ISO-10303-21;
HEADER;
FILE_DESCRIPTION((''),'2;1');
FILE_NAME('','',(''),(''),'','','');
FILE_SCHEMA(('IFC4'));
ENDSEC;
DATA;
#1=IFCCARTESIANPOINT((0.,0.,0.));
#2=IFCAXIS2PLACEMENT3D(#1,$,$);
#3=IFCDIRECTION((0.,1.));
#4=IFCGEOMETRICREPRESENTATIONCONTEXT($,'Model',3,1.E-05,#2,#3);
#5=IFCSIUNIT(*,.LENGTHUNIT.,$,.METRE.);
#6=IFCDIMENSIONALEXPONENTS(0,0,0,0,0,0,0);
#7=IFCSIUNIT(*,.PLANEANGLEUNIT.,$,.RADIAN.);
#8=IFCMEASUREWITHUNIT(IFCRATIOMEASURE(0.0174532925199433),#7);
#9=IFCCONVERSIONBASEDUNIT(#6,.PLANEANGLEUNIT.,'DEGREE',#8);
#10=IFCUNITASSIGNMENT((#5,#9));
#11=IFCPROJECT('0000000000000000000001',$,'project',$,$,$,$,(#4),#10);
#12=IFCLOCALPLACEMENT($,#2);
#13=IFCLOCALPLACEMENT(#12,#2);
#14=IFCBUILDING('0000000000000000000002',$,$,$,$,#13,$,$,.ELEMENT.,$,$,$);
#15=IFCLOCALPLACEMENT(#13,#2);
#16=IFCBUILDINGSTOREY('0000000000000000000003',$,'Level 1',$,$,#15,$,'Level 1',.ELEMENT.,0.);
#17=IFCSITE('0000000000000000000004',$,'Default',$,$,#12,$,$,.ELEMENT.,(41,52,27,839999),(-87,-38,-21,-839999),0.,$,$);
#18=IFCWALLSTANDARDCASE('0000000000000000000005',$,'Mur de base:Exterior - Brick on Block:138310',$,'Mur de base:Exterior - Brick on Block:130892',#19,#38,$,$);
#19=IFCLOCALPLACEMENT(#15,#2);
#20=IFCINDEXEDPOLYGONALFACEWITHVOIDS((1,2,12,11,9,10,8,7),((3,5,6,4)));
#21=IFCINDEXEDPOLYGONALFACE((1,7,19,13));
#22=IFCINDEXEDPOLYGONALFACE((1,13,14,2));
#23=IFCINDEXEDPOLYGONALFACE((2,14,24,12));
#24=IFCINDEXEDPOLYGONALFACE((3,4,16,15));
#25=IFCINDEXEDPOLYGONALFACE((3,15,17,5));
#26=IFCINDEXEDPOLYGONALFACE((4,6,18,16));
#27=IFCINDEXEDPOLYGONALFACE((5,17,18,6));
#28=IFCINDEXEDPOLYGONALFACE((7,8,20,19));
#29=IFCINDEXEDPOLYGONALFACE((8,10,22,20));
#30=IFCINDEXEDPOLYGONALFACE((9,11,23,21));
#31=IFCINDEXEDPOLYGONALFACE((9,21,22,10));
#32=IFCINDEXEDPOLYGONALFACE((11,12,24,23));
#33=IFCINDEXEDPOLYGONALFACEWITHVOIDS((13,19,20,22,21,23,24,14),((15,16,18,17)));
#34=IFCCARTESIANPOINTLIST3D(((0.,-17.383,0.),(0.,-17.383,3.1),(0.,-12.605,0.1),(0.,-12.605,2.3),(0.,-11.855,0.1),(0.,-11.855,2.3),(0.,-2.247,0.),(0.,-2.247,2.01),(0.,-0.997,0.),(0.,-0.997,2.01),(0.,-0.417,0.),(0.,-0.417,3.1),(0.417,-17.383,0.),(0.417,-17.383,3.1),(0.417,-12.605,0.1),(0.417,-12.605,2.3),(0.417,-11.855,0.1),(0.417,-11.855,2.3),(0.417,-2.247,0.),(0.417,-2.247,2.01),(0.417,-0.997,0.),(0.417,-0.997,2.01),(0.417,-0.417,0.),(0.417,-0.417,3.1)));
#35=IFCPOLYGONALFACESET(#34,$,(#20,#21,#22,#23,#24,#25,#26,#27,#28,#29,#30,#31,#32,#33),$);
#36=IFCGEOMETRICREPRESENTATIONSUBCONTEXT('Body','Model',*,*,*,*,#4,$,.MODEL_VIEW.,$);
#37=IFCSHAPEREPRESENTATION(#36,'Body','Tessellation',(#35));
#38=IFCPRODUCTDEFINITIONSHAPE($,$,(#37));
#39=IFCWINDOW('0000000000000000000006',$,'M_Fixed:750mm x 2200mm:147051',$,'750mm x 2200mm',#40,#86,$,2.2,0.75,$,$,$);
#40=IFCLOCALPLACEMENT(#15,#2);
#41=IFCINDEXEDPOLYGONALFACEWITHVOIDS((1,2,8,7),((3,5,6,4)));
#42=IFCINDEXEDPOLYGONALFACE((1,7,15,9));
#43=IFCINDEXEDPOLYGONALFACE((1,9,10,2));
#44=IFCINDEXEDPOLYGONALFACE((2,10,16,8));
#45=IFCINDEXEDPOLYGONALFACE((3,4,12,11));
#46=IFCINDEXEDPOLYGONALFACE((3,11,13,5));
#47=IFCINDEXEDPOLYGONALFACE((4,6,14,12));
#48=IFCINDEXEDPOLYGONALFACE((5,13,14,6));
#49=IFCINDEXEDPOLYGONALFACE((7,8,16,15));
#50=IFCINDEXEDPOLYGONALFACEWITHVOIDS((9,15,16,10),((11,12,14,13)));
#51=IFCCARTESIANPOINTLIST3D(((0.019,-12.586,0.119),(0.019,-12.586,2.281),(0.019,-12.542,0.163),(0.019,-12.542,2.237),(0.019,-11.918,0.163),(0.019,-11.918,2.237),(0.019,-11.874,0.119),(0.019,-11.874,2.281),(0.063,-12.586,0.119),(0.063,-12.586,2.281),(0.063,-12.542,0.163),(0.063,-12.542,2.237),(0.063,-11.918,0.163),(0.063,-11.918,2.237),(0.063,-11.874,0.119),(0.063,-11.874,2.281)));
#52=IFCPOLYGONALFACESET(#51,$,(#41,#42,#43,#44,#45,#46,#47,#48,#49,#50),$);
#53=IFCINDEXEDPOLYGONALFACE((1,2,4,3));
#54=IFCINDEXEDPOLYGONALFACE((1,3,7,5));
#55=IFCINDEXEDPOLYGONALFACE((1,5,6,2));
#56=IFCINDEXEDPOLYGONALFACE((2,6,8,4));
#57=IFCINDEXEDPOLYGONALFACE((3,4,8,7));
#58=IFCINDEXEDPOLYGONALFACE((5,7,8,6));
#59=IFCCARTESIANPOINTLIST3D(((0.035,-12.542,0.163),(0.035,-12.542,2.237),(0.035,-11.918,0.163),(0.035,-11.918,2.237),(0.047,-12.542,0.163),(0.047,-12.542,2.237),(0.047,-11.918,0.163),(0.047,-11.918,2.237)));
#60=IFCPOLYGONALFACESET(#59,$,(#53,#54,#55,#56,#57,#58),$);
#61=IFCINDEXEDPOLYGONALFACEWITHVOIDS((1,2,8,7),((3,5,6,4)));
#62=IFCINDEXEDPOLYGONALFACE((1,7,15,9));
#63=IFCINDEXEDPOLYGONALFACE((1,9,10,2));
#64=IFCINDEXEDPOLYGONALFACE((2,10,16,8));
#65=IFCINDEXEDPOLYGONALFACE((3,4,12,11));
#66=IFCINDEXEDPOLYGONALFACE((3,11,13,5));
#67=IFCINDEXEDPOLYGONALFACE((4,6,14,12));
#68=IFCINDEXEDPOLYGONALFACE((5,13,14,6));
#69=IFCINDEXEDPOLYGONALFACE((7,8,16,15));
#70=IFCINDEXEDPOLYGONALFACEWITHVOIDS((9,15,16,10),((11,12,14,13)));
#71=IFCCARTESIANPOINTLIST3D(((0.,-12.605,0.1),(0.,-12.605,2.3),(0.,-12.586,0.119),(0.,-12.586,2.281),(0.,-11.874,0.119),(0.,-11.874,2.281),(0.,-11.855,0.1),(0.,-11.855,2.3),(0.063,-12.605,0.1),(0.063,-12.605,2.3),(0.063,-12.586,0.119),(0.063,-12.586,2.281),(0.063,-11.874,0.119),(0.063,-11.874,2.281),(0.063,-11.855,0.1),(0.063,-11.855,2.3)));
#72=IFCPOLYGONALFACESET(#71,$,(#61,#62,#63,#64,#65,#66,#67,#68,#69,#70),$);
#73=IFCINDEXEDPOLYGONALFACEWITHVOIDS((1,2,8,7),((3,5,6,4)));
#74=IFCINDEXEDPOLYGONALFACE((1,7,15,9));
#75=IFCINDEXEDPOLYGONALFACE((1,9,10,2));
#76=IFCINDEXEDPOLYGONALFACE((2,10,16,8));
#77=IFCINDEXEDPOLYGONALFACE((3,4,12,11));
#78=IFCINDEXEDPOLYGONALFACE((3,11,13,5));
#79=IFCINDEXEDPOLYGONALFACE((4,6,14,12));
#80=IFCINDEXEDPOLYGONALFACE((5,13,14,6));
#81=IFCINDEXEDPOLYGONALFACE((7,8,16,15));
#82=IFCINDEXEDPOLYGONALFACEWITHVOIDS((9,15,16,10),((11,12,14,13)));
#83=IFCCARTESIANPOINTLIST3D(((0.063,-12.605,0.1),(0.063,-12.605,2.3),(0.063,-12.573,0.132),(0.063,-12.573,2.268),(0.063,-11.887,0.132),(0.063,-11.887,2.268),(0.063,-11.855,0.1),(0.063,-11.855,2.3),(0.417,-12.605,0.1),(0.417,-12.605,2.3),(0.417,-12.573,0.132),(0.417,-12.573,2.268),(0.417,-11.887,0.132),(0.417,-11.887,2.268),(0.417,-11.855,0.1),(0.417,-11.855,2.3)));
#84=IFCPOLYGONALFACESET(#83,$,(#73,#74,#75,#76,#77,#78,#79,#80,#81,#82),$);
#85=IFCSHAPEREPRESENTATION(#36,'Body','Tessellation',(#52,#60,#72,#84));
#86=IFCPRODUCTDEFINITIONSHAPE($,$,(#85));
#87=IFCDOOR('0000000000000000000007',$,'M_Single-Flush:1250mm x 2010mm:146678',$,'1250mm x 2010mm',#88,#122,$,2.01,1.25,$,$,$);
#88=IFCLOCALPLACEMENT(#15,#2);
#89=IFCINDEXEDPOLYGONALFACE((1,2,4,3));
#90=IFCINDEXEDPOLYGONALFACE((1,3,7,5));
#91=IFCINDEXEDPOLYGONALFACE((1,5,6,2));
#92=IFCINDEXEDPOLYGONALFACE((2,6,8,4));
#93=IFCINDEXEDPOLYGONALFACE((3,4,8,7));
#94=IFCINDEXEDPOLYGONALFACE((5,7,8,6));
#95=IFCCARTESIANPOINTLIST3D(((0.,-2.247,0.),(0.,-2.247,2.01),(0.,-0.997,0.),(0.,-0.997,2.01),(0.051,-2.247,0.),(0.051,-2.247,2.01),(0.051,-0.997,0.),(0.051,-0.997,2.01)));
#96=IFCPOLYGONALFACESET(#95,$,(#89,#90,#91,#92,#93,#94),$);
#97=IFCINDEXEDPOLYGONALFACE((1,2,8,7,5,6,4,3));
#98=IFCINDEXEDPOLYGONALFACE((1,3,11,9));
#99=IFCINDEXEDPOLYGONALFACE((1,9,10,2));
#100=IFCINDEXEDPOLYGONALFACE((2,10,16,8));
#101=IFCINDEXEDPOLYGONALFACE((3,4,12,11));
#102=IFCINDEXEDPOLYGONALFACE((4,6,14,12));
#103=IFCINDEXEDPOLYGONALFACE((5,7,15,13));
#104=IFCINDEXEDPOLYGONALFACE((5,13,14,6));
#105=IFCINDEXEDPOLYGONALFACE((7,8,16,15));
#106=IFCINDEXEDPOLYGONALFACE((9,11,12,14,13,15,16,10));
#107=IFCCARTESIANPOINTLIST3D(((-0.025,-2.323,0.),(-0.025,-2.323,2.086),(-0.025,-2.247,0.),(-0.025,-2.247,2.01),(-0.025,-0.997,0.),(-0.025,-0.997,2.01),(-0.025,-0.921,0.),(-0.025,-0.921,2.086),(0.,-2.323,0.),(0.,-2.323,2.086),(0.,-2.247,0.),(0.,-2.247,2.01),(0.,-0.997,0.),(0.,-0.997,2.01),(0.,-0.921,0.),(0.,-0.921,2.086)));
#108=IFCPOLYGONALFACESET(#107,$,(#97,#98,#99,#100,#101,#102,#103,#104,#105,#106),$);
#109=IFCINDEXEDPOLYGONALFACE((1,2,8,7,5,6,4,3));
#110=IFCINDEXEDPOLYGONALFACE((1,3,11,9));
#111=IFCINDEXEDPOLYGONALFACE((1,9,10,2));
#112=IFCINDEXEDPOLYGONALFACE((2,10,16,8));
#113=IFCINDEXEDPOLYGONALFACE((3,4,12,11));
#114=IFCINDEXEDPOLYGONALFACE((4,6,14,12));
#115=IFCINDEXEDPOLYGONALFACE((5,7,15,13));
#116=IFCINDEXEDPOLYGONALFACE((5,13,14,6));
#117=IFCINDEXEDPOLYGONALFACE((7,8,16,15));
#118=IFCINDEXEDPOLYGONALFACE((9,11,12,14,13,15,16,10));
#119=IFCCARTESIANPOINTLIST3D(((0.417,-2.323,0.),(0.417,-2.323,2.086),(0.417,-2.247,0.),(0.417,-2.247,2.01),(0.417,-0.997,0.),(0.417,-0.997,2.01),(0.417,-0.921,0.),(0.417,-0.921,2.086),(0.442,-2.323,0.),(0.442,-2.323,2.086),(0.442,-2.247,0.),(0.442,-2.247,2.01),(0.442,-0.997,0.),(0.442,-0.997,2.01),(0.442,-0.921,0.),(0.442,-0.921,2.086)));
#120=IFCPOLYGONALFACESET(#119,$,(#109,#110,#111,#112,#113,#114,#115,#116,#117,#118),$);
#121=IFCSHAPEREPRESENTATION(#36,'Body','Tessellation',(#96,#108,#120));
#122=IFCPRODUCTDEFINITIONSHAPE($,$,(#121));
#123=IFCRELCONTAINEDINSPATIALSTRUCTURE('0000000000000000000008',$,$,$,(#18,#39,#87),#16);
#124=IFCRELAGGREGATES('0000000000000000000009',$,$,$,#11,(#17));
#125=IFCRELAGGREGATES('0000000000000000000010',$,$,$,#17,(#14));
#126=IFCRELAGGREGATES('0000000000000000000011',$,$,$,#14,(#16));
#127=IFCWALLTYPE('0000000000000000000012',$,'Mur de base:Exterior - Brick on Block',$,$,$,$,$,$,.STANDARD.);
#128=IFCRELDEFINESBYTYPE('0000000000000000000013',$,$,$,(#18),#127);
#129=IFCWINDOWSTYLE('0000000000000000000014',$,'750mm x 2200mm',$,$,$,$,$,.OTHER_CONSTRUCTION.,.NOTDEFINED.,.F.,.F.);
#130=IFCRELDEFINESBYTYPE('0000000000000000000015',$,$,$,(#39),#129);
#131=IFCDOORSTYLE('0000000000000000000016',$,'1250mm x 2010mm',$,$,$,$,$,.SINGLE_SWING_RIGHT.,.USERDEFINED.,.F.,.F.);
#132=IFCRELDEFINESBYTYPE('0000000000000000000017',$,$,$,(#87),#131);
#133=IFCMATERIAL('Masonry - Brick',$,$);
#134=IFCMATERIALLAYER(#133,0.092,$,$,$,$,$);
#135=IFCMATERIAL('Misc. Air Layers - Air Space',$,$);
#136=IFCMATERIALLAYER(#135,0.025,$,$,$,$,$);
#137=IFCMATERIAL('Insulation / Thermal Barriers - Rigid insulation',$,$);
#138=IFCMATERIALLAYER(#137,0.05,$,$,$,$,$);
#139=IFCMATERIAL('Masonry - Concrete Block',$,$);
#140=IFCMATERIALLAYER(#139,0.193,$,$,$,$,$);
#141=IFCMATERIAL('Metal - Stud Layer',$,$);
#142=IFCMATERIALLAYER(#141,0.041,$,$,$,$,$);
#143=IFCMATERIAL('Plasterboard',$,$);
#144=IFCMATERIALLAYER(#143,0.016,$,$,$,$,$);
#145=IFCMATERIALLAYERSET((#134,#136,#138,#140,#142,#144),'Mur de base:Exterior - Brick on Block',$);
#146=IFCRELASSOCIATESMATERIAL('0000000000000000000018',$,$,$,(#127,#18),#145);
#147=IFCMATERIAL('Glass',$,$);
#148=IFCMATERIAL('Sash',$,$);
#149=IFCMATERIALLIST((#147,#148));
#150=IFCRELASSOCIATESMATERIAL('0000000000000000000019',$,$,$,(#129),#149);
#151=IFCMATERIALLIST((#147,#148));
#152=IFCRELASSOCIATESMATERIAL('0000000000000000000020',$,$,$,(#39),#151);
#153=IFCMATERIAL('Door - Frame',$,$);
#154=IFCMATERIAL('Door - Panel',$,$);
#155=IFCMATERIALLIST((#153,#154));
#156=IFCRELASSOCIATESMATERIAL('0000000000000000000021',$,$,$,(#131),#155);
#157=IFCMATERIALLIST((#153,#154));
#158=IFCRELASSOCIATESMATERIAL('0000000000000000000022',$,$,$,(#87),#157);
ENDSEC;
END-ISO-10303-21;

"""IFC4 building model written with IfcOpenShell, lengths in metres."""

from ifc_helpers import new_model, entity, si_unit, converted_unit, direction, frame, frame_2d, origin, origin_2d_with_axis, place, context, subcontext, project, spatial, polyline, rectangle, outline, extrude, source, transform, mapped, material, material_list, layer, layer_set, layer_usage, type_object, type_shapes, element, fill, save


model = new_model("IFC4")

# Units and contexts
model_context = context("Model", 3, precision=1e-05, world=origin(), true_north=direction((0.0, 1.0)))
body_context = subcontext(model_context, "Body", "Model", "MODEL_VIEW")
ifc_project = project(units=[si_unit("LENGTHUNIT", "METRE"), converted_unit("PLANEANGLEUNIT", "DEGREE", entity("IfcRatioMeasure", 0.0174532925199433), si_unit("PLANEANGLEUNIT", "RADIAN"), dimensions=[0, 0, 0, 0, 0, 0, 0])], contexts=[model_context])

# Site, building, storey
site_placement = place(None, origin())
site = spatial("IfcSite", under=ifc_project, at=site_placement, Name="Default", CompositionType="ELEMENT", RefLatitude=(41, 52, 27, 839999), RefLongitude=(-87, -38, -21, -839999), RefElevation=0.0)
building_placement = place(site_placement, origin())
building = spatial("IfcBuilding", under=site, at=building_placement, CompositionType="ELEMENT")
storey_placement = place(building_placement, origin())
storey = spatial("IfcBuildingStorey", under=building, at=storey_placement, Name="Level 1", LongName="Level 1", CompositionType="ELEMENT", Elevation=0.0)

# Shared definitions
ifc_material_1 = material(Name="Plasterboard")
ifc_material_2 = material(Name="Metal - Stud Layer")
ifc_material_3 = material(Name="Door - Frame")
ifc_material_4 = material(Name="Door - Panel")

# Wall, openings, window, door
ifc_material_5 = material(Name="Masonry - Brick")
ifc_layer_1 = layer(ifc_material_5, 0.092)
ifc_material_6 = material(Name="Misc. Air Layers - Air Space")
ifc_layer_2 = layer(ifc_material_6, 0.025)
ifc_material_7 = material(Name="Insulation / Thermal Barriers - Rigid insulation")
ifc_layer_3 = layer(ifc_material_7, 0.05)
ifc_material_8 = material(Name="Masonry - Concrete Block")
ifc_layer_4 = layer(ifc_material_8, 0.193)
ifc_layer_5 = layer(ifc_material_2, 0.041)
ifc_layer_6 = layer(ifc_material_1, 0.016)
ifc_layer_set_1 = layer_set([ifc_layer_1, ifc_layer_2, ifc_layer_3, ifc_layer_4, ifc_layer_5, ifc_layer_6], Name="Mur de base:Exterior - Brick on Block")
ifc_layer_usage_1 = layer_usage(ifc_layer_set_1, "AXIS2", "NEGATIVE", 0.2085)
wall_type_1 = type_object("IfcWallType", Name="Mur de base:Exterior - Brick on Block", PredefinedType="STANDARD", material=ifc_layer_set_1)
wall_1_placement = place(storey_placement, frame((0.2085, -17.383, 0.0), z_axis=(0.0, 0.0, 1.0), x_axis=(0.0, 1.0, 0.0)))
wall_1 = element("IfcWallStandardCase", 1, at=wall_1_placement, inside=storey, type_object=wall_type_1, material=ifc_layer_usage_1, Name="Mur de base:Exterior - Brick on Block:138310", ObjectType="Mur de base:Exterior - Brick on Block:130892", context=body_context, shape_type="SweptSolid", body=[
    extrude(rectangle(XDim=16.966, YDim=0.417, at=frame_2d((8.483, 0.0), x_axis=(-1.0, 0.0))), origin(), (0.0, 0.0, 1.0), 3.1),
])
opening_1_placement = place(wall_1_placement, frame((4.778, -0.2085, 0.1)))
opening_1 = element("IfcOpeningElement", 2, at=opening_1_placement, cuts=wall_1, ObjectType="Opening", context=body_context, shape_type="SweptSolid", body=[
    extrude(rectangle(XDim=2.2, YDim=0.75, at=frame_2d((1.1, 0.375), x_axis=(1.0, 0.0))), frame((0.0, 0.0, 0.0), z_axis=(0.0, 1.0, 0.0), x_axis=(0.0, 0.0, 1.0)), (0.0, 0.0, 1.0), 0.417),
])
opening_2_placement = place(wall_1_placement, frame((15.136, -0.2085, 0.0)))
opening_2 = element("IfcOpeningElement", 3, at=opening_2_placement, cuts=wall_1, ObjectType="Opening", context=body_context, shape_type="SweptSolid", body=[
    extrude(rectangle(XDim=1.25, YDim=2.01, at=frame_2d((1.005, 0.625), x_axis=(0.0, 1.0))), frame((0.0, 0.0, 0.0), z_axis=(0.0, 1.0, 0.0), x_axis=(0.0, 0.0, 1.0)), (0.0, 0.0, 1.0), 0.417),
])
ifc_material_9 = material(Name="Glass")
ifc_material_10 = material(Name="Sash")
ifc_material_list_1 = material_list([ifc_material_9, ifc_material_10])
ifc_material_list_2 = material_list([ifc_material_9, ifc_material_10])
window_style_1 = type_object("IfcWindowStyle", Name="750mm x 2200mm", ConstructionType="OTHER_CONSTRUCTION", OperationType="NOTDEFINED", ParameterTakesPrecedence=False, Sizeable=False, material=ifc_material_list_2)
shared_shape_1 = source(origin(), body_context, "Body", "SweptSolid", [
    extrude(outline(polyline([(-0.356, -1.081), (0.356, -1.081), (0.356, 1.081), (-0.356, 1.081), (-0.356, -1.081)]), holes=[polyline([(-0.312, -1.037), (-0.312, 1.037), (0.312, 1.037), (0.312, -1.037), (-0.312, -1.037)])]), frame((0.375, 0.354, 1.1), z_axis=(0.0, 1.0, 0.0), x_axis=(1.0, 0.0, 0.0)), (0.0, 0.0, 1.0), 0.044),
    extrude(rectangle(XDim=0.012, YDim=0.624, at=origin_2d_with_axis()), frame((0.375, 0.376, 0.063), z_axis=(0.0, 0.0, 1.0), x_axis=(0.0, -1.0, 0.0)), (0.0, 0.0, 1.0), 2.074),
    extrude(outline(polyline([(-0.375, -1.1), (0.375, -1.1), (0.375, 1.1), (-0.375, 1.1), (-0.375, -1.1)]), holes=[polyline([(-0.356, -1.081), (-0.356, 1.081), (0.356, 1.081), (0.356, -1.081), (-0.356, -1.081)])]), frame((0.375, 0.354, 1.1), z_axis=(0.0, 1.0, 0.0), x_axis=(1.0, 0.0, 0.0)), (0.0, 0.0, 1.0), 0.063),
    extrude(outline(polyline([(-0.375, -1.1), (0.375, -1.1), (0.375, 1.1), (-0.375, 1.1), (-0.375, -1.1)]), holes=[polyline([(-0.343, -1.068), (-0.343, 1.068), (0.343, 1.068), (0.343, -1.068), (-0.343, -1.068)])]), frame((0.375, 0.0, 1.1), z_axis=(0.0, 1.0, 0.0), x_axis=(1.0, 0.0, 0.0)), (0.0, 0.0, 1.0), 0.354),
])
type_shapes(window_style_1, [shared_shape_1])
window_1_placement = place(opening_1_placement, origin())
window_1 = element("IfcWindow", 4, at=window_1_placement, inside=storey, type_object=window_style_1, material=ifc_material_list_1, Name="M_Fixed:750mm x 2200mm:147051", ObjectType="750mm x 2200mm", OverallHeight=2.2, OverallWidth=0.75, context=body_context, shape_type="MappedRepresentation", body=[
    mapped(shared_shape_1, transform((0.0, 0.0, 0.0), scale=1.0)),
])
fill(opening_1, window_1)
ifc_material_list_3 = material_list([ifc_material_3, ifc_material_4])
ifc_material_list_4 = material_list([ifc_material_3, ifc_material_4])
door_style_1 = type_object("IfcDoorStyle", Name="1250mm x 2010mm", ConstructionType="USERDEFINED", OperationType="SINGLE_SWING_RIGHT", ParameterTakesPrecedence=False, Sizeable=False, material=ifc_material_list_4)
shared_shape_2 = source(origin(), body_context, "Body", "SweptSolid", [
    extrude(rectangle(XDim=0.051, YDim=1.25, at=frame_2d((0.0, 0.0), x_axis=(1.0, 0.0))), frame((0.625, 0.3915, 0.0), z_axis=(0.0, 0.0, 1.0), x_axis=(0.0, 1.0, 0.0)), (0.0, 0.0, 1.0), 2.01),
    extrude(outline(polyline([(-0.701, -1.062), (0.701, -1.062), (0.701, 1.024), (0.625, 1.024), (0.625, -0.986), (-0.625, -0.986), (-0.625, 1.024), (-0.701, 1.024), (-0.701, -1.062)])), frame((0.625, 0.417, 1.024), z_axis=(0.0, 1.0, 0.0), x_axis=(1.0, 0.0, 0.0)), (0.0, 0.0, 1.0), 0.025),
    extrude(outline(polyline([(-1.062, -0.701), (1.024, -0.701), (1.024, -0.625), (-0.986, -0.625), (-0.986, 0.625), (1.024, 0.625), (1.024, 0.701), (-1.062, 0.701), (-1.062, -0.701)])), frame((0.625, -0.025, 1.024), z_axis=(0.0, 1.0, 0.0), x_axis=(0.0, 0.0, -1.0)), (0.0, 0.0, 1.0), 0.025),
])
type_shapes(door_style_1, [shared_shape_2])
door_1_placement = place(opening_2_placement, origin())
door_1 = element("IfcDoor", 5, at=door_1_placement, inside=storey, type_object=door_style_1, material=ifc_material_list_3, Name="M_Single-Flush:1250mm x 2010mm:146678", ObjectType="1250mm x 2010mm", OverallHeight=2.01, OverallWidth=1.25, context=body_context, shape_type="MappedRepresentation", body=[
    mapped(shared_shape_2, transform((0.0, 0.0, 0.0), scale=1.0)),
])
fill(opening_2, door_1)

save(model, "model.ifc")
